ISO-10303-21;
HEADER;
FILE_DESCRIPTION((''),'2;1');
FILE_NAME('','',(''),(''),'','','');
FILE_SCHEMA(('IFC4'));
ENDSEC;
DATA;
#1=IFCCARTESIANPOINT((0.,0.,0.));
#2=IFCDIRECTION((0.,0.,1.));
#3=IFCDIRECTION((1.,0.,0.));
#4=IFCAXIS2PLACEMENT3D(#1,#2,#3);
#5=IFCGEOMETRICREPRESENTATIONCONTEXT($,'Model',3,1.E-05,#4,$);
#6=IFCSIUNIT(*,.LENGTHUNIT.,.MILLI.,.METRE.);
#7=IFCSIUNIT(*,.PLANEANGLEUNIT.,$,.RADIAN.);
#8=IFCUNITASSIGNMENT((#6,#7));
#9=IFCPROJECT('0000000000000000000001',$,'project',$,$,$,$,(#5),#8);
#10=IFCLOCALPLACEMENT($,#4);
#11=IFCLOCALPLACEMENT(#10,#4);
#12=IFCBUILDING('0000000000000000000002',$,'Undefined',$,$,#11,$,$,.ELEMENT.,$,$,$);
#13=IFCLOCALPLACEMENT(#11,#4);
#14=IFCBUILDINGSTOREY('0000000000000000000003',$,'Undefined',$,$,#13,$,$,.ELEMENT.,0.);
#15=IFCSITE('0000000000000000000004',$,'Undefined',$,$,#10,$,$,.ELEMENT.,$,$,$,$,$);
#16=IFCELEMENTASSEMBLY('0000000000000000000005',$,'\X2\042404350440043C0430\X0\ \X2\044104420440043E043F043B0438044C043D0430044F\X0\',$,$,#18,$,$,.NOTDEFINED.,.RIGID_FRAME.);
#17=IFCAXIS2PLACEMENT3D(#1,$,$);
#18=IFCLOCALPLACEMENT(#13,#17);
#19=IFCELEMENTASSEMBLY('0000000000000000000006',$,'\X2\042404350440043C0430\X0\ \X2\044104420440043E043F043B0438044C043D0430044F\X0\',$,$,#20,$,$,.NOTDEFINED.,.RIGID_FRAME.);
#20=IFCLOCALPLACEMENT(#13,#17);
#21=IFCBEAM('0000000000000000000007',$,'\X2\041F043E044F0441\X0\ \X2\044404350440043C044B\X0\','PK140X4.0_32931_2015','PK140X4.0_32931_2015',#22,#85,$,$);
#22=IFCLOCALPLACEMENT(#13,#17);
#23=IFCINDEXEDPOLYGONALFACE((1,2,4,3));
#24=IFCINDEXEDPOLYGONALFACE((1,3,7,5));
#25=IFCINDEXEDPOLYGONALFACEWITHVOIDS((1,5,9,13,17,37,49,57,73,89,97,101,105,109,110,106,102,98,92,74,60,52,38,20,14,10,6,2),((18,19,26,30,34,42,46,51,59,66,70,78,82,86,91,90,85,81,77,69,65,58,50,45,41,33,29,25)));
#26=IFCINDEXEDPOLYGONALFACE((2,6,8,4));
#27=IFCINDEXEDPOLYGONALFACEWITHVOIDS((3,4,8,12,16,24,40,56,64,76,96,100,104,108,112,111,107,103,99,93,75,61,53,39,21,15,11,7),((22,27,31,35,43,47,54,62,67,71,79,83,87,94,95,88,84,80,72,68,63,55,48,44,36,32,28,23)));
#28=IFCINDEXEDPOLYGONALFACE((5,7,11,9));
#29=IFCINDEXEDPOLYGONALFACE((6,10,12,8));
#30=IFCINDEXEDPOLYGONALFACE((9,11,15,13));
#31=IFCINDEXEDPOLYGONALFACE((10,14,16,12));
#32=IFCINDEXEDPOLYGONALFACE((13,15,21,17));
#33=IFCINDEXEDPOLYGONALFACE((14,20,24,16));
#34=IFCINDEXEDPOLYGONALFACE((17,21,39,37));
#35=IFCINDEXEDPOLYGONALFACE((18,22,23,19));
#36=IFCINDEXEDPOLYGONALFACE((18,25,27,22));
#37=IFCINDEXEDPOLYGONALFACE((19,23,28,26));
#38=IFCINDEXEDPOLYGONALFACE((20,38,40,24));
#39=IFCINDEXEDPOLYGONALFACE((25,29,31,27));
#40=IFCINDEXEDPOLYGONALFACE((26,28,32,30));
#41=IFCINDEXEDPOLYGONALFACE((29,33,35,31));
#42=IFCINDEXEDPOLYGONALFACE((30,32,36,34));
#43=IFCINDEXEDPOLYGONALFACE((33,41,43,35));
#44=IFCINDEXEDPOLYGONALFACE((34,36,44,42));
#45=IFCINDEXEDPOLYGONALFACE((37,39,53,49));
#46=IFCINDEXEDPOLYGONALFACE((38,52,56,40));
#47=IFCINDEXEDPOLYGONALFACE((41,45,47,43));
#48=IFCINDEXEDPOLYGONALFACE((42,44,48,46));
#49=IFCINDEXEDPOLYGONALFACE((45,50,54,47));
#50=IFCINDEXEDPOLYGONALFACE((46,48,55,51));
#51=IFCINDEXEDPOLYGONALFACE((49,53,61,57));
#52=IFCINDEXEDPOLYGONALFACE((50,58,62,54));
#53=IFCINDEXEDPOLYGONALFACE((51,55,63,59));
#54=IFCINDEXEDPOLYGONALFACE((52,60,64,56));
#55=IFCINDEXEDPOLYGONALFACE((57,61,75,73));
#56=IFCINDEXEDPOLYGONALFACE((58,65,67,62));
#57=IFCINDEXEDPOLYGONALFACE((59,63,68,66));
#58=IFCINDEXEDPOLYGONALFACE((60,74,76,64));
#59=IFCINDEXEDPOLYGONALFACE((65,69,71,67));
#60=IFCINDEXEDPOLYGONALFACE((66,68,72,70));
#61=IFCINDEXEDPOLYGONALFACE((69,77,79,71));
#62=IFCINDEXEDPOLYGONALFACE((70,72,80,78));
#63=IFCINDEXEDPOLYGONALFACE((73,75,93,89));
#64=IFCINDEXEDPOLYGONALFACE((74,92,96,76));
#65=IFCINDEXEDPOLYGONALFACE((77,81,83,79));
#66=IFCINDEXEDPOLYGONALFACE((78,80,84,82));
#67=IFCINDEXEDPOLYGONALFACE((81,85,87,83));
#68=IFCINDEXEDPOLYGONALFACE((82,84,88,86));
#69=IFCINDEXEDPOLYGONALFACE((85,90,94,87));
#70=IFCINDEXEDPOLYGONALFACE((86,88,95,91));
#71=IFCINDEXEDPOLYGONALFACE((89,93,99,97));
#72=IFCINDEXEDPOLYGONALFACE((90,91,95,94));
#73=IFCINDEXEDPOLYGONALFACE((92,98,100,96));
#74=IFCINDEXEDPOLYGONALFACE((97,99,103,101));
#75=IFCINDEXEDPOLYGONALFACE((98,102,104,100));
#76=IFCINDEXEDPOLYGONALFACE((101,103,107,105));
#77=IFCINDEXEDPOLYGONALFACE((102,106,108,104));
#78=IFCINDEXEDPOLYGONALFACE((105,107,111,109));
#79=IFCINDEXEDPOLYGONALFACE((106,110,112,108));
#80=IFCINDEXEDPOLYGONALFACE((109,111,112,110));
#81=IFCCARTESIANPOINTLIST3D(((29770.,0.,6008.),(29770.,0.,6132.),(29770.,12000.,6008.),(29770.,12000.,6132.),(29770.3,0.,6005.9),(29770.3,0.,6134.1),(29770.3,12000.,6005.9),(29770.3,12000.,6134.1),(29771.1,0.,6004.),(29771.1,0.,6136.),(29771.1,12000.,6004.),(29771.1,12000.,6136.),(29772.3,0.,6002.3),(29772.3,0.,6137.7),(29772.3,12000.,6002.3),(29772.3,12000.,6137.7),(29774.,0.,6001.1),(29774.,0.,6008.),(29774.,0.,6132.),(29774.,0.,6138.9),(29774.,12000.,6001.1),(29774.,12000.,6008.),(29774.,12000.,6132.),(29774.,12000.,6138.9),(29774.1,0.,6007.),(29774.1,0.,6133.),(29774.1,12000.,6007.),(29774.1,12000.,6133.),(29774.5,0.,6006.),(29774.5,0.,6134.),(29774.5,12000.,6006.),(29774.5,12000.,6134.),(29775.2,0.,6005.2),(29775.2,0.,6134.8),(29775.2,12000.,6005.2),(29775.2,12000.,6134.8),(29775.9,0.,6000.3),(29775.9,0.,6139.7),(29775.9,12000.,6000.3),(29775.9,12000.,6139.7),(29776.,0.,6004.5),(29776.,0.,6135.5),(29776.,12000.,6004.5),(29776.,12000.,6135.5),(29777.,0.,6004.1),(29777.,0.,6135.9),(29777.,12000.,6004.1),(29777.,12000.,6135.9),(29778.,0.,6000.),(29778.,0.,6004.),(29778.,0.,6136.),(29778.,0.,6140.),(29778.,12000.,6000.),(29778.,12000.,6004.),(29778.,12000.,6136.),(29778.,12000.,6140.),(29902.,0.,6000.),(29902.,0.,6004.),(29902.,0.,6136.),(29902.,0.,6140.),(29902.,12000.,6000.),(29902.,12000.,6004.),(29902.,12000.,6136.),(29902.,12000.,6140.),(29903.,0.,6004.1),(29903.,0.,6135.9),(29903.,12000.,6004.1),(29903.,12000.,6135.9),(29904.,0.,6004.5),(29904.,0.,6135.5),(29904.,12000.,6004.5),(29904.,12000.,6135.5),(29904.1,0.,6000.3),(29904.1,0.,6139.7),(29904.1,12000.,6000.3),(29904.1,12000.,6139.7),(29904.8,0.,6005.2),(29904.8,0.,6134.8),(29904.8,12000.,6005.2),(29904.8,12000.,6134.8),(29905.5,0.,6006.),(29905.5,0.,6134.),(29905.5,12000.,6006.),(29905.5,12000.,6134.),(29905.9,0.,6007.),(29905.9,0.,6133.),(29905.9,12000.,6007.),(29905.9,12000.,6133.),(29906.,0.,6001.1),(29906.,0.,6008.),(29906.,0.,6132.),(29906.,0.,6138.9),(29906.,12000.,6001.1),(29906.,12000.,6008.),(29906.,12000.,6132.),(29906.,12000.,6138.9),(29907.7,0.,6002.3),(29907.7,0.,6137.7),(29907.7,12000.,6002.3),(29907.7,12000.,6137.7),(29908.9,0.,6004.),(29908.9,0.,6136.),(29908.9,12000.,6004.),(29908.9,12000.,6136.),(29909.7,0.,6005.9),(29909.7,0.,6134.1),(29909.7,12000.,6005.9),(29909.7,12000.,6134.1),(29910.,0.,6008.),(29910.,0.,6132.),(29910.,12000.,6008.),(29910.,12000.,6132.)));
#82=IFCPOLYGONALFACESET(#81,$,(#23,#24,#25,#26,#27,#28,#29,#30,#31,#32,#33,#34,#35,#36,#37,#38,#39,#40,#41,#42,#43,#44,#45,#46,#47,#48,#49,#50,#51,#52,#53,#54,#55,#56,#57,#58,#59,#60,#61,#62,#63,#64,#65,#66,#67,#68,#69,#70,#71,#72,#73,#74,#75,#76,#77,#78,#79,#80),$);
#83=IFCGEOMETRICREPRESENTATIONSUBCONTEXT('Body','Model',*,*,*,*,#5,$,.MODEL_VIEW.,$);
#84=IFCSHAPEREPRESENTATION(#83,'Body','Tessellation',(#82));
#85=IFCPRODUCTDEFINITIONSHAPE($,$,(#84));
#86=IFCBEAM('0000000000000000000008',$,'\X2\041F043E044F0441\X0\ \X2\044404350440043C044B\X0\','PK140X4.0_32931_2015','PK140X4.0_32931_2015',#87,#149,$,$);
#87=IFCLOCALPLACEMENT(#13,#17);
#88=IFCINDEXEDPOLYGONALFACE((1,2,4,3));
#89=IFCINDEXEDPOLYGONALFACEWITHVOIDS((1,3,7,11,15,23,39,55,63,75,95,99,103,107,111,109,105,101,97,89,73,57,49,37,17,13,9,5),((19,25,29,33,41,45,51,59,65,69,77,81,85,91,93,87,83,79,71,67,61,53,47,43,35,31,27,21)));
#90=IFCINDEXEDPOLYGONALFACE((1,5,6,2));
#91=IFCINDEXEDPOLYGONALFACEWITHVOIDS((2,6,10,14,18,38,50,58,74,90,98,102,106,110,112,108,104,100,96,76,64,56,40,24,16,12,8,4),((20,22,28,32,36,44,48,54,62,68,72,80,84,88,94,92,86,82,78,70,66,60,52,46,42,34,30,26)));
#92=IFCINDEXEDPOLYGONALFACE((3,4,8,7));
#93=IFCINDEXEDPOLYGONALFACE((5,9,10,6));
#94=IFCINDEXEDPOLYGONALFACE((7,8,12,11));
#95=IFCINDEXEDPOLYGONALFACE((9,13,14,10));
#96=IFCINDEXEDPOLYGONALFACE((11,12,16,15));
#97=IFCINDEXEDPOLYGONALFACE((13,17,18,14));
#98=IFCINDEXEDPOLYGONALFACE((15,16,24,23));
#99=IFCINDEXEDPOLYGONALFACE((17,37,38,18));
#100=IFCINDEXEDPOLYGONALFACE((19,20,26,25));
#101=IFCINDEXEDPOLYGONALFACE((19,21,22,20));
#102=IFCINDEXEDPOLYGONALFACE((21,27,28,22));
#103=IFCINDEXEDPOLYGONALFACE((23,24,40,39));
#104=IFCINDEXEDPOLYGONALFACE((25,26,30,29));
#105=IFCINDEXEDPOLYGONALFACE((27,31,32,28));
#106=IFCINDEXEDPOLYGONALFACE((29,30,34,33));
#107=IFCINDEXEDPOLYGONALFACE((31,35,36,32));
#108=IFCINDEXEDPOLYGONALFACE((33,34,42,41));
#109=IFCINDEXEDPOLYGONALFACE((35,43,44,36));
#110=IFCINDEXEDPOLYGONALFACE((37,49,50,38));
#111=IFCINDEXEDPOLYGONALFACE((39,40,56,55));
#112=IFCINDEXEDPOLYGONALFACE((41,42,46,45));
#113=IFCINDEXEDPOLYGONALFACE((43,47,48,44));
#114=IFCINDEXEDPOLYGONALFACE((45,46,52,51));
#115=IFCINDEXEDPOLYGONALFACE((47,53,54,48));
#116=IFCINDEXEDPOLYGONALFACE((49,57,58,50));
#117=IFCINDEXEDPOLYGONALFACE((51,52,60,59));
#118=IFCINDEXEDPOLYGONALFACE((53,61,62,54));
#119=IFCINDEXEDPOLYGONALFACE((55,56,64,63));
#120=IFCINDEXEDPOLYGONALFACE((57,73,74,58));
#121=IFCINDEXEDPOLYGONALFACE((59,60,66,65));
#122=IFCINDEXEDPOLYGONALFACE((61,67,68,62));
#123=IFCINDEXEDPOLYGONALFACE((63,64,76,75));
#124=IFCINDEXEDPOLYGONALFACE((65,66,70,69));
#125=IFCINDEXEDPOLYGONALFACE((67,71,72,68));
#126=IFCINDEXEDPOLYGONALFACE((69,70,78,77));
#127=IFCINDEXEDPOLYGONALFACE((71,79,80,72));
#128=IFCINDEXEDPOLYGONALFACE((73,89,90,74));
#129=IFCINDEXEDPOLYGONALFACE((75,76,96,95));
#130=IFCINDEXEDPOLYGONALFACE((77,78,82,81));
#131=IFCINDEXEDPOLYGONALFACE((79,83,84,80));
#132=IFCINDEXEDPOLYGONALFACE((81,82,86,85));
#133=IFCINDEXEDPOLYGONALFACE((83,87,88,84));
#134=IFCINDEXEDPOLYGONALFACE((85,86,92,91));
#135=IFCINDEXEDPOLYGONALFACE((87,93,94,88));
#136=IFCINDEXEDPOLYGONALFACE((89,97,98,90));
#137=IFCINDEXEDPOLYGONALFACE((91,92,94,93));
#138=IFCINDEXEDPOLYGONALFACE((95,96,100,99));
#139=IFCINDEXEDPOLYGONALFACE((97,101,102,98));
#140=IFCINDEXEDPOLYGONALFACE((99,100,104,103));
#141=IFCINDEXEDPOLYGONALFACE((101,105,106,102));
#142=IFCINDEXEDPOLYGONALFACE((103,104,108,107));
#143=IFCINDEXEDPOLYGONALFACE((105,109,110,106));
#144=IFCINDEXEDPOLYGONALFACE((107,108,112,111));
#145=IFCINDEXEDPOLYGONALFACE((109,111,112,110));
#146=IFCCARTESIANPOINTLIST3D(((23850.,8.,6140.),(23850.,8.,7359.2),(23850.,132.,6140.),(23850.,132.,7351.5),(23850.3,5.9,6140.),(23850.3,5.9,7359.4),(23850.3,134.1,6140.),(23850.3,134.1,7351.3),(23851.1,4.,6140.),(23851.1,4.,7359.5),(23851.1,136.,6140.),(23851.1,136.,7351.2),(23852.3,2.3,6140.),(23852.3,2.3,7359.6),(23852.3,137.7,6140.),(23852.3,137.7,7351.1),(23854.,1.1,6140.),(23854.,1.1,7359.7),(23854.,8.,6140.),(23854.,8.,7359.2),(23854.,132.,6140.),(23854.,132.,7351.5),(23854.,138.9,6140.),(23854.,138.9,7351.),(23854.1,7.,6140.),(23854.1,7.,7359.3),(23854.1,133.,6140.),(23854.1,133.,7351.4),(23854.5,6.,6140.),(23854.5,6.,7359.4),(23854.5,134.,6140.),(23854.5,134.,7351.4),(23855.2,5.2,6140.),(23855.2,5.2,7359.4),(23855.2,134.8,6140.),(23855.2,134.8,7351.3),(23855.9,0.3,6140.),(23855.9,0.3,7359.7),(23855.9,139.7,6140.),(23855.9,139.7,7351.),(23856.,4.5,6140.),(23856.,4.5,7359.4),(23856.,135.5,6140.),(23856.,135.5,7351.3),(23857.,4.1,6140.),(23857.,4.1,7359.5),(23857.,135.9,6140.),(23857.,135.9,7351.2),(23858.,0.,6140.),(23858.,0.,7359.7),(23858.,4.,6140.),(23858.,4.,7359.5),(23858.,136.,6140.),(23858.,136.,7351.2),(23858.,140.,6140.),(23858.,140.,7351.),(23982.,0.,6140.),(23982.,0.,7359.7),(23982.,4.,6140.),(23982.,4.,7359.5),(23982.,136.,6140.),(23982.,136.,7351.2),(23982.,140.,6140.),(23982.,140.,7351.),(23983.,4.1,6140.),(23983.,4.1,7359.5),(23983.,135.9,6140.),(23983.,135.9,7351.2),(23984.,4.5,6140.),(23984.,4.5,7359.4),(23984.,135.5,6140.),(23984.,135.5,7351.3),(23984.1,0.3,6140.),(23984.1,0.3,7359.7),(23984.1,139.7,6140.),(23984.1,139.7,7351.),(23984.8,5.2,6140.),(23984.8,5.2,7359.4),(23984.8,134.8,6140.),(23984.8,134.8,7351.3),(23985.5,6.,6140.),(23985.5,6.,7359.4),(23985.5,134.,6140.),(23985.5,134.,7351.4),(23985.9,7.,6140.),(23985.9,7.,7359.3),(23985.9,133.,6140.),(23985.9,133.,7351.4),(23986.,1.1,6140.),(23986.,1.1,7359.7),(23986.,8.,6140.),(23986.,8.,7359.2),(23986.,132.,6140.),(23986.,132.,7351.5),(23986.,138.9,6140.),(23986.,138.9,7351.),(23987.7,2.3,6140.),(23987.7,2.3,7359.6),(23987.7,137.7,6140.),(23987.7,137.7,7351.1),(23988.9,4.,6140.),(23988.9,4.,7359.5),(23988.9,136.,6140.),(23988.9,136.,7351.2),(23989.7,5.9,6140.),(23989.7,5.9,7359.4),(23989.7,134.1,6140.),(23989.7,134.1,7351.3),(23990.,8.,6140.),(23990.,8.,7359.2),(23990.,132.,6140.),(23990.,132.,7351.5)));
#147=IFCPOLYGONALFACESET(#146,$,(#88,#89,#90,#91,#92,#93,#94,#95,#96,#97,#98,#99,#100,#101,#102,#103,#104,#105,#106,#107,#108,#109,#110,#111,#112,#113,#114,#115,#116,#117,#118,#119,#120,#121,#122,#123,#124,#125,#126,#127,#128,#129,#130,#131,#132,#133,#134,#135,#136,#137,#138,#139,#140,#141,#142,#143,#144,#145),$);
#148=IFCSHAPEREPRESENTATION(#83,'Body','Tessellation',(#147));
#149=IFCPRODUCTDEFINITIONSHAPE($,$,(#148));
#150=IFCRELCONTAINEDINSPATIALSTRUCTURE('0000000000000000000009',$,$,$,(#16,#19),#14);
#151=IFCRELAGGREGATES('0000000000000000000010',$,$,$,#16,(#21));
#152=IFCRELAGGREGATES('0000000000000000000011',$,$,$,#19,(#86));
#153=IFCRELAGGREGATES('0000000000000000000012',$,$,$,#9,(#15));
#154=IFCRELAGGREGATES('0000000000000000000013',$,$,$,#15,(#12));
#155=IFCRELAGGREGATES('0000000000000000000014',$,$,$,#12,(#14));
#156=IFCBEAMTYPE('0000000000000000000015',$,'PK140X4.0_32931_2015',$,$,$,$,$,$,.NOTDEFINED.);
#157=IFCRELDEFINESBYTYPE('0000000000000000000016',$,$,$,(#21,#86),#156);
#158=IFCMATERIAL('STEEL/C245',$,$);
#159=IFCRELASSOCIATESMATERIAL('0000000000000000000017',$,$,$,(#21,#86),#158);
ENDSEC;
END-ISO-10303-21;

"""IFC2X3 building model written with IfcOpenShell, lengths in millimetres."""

from ifc_helpers import new_model, si_unit, frame, origin_with_axes, origin_2d_with_axis, place, context, subcontext, project, spatial, hollow_rectangle, extrude, clip, halfspace, material, type_object, element, aggregate, save


model = new_model("IFC2X3")

# Units and contexts
model_context = context("Model", 3, precision=1e-05, world=origin_with_axes())
body_context = subcontext(model_context, "Body", "Model", "MODEL_VIEW")
ifc_project = project(units=[si_unit("LENGTHUNIT", "METRE", prefix="MILLI"), si_unit("PLANEANGLEUNIT", "RADIAN")], contexts=[model_context])

# Site, building, storey
site_placement = place(None, origin_with_axes())
site = spatial("IfcSite", under=ifc_project, at=site_placement, Name="Undefined", CompositionType="ELEMENT")
building_placement = place(site_placement, origin_with_axes())
building = spatial("IfcBuilding", under=site, at=building_placement, Name="Undefined", CompositionType="ELEMENT")
storey_placement = place(building_placement, origin_with_axes())
storey = spatial("IfcBuildingStorey", under=building, at=storey_placement, Name="Undefined", CompositionType="ELEMENT", Elevation=0.0)

# Shared definitions
ifc_material = material(Name="STEEL/C245")

# Element assemblies
assembly_1_placement = place(storey_placement, origin_with_axes())
assembly_1 = element("IfcElementAssembly", 1, at=assembly_1_placement, inside=storey, Name="Ферма строплиьная", AssemblyPlace="NOTDEFINED", PredefinedType="RIGID_FRAME")
assembly_2_placement = place(storey_placement, origin_with_axes())
assembly_2 = element("IfcElementAssembly", 2, at=assembly_2_placement, inside=storey, Name="Ферма строплиьная", AssemblyPlace="NOTDEFINED", PredefinedType="RIGID_FRAME")

# Beams
beam_type_1 = type_object("IfcBeamType", Name="PK140X4.0_32931_2015", PredefinedType="NOTDEFINED")
beam_1_placement = place(assembly_1_placement, frame((29840.0, 0.0, 6070.0), z_axis=(0.0, 0.0, 1.0), x_axis=(0.0, 1.0, 0.0)))
beam_1 = element("IfcBeam", 3, at=beam_1_placement, type_object=beam_type_1, material=ifc_material, Name="Пояс фермы", Description="PK140X4.0_32931_2015", ObjectType="PK140X4.0_32931_2015", context=body_context, shape_type="SweptSolid", body=[
    extrude(hollow_rectangle(XDim=140.0, YDim=140.0, WallThickness=4.0, InnerFilletRadius=4.0, OuterFilletRadius=8.0, at=origin_2d_with_axis()), frame((12000.0, 0.0, 0.0), z_axis=(-1.0, 0.0, 0.0), x_axis=(0.0, -1.0, 0.0)), (0.0, 0.0, 1.0), 12000.0),
])
aggregate(assembly_1, [beam_1])
beam_2_placement = place(assembly_2_placement, frame((23920.0, 70.0, 7359.7), z_axis=(1.0, 0.0, 0.0), x_axis=(0.0, 0.0, -1.0)))
beam_2 = element("IfcBeam", 4, at=beam_2_placement, type_object=beam_type_1, material=ifc_material, Name="Пояс фермы", Description="PK140X4.0_32931_2015", ObjectType="PK140X4.0_32931_2015", context=body_context, shape_type="Clipping", body=[
    clip(extrude(hollow_rectangle(XDim=140.0, YDim=140.0, WallThickness=4.0, InnerFilletRadius=4.0, OuterFilletRadius=8.0, at=origin_2d_with_axis()), frame((1219.7, 0.0, 0.0), z_axis=(-1.0, 0.0, 0.0), x_axis=(0.0, -1.0, 0.0)), (0.0, 0.0, 1.0), 1219.8), halfspace(frame((10.5, 98.4, 0.0), z_axis=(0.998053, -0.062378, 0.0), x_axis=(0.0, 0.0, 1.0)), True)),
])
aggregate(assembly_2, [beam_2])

save(model, "model.ifc")
